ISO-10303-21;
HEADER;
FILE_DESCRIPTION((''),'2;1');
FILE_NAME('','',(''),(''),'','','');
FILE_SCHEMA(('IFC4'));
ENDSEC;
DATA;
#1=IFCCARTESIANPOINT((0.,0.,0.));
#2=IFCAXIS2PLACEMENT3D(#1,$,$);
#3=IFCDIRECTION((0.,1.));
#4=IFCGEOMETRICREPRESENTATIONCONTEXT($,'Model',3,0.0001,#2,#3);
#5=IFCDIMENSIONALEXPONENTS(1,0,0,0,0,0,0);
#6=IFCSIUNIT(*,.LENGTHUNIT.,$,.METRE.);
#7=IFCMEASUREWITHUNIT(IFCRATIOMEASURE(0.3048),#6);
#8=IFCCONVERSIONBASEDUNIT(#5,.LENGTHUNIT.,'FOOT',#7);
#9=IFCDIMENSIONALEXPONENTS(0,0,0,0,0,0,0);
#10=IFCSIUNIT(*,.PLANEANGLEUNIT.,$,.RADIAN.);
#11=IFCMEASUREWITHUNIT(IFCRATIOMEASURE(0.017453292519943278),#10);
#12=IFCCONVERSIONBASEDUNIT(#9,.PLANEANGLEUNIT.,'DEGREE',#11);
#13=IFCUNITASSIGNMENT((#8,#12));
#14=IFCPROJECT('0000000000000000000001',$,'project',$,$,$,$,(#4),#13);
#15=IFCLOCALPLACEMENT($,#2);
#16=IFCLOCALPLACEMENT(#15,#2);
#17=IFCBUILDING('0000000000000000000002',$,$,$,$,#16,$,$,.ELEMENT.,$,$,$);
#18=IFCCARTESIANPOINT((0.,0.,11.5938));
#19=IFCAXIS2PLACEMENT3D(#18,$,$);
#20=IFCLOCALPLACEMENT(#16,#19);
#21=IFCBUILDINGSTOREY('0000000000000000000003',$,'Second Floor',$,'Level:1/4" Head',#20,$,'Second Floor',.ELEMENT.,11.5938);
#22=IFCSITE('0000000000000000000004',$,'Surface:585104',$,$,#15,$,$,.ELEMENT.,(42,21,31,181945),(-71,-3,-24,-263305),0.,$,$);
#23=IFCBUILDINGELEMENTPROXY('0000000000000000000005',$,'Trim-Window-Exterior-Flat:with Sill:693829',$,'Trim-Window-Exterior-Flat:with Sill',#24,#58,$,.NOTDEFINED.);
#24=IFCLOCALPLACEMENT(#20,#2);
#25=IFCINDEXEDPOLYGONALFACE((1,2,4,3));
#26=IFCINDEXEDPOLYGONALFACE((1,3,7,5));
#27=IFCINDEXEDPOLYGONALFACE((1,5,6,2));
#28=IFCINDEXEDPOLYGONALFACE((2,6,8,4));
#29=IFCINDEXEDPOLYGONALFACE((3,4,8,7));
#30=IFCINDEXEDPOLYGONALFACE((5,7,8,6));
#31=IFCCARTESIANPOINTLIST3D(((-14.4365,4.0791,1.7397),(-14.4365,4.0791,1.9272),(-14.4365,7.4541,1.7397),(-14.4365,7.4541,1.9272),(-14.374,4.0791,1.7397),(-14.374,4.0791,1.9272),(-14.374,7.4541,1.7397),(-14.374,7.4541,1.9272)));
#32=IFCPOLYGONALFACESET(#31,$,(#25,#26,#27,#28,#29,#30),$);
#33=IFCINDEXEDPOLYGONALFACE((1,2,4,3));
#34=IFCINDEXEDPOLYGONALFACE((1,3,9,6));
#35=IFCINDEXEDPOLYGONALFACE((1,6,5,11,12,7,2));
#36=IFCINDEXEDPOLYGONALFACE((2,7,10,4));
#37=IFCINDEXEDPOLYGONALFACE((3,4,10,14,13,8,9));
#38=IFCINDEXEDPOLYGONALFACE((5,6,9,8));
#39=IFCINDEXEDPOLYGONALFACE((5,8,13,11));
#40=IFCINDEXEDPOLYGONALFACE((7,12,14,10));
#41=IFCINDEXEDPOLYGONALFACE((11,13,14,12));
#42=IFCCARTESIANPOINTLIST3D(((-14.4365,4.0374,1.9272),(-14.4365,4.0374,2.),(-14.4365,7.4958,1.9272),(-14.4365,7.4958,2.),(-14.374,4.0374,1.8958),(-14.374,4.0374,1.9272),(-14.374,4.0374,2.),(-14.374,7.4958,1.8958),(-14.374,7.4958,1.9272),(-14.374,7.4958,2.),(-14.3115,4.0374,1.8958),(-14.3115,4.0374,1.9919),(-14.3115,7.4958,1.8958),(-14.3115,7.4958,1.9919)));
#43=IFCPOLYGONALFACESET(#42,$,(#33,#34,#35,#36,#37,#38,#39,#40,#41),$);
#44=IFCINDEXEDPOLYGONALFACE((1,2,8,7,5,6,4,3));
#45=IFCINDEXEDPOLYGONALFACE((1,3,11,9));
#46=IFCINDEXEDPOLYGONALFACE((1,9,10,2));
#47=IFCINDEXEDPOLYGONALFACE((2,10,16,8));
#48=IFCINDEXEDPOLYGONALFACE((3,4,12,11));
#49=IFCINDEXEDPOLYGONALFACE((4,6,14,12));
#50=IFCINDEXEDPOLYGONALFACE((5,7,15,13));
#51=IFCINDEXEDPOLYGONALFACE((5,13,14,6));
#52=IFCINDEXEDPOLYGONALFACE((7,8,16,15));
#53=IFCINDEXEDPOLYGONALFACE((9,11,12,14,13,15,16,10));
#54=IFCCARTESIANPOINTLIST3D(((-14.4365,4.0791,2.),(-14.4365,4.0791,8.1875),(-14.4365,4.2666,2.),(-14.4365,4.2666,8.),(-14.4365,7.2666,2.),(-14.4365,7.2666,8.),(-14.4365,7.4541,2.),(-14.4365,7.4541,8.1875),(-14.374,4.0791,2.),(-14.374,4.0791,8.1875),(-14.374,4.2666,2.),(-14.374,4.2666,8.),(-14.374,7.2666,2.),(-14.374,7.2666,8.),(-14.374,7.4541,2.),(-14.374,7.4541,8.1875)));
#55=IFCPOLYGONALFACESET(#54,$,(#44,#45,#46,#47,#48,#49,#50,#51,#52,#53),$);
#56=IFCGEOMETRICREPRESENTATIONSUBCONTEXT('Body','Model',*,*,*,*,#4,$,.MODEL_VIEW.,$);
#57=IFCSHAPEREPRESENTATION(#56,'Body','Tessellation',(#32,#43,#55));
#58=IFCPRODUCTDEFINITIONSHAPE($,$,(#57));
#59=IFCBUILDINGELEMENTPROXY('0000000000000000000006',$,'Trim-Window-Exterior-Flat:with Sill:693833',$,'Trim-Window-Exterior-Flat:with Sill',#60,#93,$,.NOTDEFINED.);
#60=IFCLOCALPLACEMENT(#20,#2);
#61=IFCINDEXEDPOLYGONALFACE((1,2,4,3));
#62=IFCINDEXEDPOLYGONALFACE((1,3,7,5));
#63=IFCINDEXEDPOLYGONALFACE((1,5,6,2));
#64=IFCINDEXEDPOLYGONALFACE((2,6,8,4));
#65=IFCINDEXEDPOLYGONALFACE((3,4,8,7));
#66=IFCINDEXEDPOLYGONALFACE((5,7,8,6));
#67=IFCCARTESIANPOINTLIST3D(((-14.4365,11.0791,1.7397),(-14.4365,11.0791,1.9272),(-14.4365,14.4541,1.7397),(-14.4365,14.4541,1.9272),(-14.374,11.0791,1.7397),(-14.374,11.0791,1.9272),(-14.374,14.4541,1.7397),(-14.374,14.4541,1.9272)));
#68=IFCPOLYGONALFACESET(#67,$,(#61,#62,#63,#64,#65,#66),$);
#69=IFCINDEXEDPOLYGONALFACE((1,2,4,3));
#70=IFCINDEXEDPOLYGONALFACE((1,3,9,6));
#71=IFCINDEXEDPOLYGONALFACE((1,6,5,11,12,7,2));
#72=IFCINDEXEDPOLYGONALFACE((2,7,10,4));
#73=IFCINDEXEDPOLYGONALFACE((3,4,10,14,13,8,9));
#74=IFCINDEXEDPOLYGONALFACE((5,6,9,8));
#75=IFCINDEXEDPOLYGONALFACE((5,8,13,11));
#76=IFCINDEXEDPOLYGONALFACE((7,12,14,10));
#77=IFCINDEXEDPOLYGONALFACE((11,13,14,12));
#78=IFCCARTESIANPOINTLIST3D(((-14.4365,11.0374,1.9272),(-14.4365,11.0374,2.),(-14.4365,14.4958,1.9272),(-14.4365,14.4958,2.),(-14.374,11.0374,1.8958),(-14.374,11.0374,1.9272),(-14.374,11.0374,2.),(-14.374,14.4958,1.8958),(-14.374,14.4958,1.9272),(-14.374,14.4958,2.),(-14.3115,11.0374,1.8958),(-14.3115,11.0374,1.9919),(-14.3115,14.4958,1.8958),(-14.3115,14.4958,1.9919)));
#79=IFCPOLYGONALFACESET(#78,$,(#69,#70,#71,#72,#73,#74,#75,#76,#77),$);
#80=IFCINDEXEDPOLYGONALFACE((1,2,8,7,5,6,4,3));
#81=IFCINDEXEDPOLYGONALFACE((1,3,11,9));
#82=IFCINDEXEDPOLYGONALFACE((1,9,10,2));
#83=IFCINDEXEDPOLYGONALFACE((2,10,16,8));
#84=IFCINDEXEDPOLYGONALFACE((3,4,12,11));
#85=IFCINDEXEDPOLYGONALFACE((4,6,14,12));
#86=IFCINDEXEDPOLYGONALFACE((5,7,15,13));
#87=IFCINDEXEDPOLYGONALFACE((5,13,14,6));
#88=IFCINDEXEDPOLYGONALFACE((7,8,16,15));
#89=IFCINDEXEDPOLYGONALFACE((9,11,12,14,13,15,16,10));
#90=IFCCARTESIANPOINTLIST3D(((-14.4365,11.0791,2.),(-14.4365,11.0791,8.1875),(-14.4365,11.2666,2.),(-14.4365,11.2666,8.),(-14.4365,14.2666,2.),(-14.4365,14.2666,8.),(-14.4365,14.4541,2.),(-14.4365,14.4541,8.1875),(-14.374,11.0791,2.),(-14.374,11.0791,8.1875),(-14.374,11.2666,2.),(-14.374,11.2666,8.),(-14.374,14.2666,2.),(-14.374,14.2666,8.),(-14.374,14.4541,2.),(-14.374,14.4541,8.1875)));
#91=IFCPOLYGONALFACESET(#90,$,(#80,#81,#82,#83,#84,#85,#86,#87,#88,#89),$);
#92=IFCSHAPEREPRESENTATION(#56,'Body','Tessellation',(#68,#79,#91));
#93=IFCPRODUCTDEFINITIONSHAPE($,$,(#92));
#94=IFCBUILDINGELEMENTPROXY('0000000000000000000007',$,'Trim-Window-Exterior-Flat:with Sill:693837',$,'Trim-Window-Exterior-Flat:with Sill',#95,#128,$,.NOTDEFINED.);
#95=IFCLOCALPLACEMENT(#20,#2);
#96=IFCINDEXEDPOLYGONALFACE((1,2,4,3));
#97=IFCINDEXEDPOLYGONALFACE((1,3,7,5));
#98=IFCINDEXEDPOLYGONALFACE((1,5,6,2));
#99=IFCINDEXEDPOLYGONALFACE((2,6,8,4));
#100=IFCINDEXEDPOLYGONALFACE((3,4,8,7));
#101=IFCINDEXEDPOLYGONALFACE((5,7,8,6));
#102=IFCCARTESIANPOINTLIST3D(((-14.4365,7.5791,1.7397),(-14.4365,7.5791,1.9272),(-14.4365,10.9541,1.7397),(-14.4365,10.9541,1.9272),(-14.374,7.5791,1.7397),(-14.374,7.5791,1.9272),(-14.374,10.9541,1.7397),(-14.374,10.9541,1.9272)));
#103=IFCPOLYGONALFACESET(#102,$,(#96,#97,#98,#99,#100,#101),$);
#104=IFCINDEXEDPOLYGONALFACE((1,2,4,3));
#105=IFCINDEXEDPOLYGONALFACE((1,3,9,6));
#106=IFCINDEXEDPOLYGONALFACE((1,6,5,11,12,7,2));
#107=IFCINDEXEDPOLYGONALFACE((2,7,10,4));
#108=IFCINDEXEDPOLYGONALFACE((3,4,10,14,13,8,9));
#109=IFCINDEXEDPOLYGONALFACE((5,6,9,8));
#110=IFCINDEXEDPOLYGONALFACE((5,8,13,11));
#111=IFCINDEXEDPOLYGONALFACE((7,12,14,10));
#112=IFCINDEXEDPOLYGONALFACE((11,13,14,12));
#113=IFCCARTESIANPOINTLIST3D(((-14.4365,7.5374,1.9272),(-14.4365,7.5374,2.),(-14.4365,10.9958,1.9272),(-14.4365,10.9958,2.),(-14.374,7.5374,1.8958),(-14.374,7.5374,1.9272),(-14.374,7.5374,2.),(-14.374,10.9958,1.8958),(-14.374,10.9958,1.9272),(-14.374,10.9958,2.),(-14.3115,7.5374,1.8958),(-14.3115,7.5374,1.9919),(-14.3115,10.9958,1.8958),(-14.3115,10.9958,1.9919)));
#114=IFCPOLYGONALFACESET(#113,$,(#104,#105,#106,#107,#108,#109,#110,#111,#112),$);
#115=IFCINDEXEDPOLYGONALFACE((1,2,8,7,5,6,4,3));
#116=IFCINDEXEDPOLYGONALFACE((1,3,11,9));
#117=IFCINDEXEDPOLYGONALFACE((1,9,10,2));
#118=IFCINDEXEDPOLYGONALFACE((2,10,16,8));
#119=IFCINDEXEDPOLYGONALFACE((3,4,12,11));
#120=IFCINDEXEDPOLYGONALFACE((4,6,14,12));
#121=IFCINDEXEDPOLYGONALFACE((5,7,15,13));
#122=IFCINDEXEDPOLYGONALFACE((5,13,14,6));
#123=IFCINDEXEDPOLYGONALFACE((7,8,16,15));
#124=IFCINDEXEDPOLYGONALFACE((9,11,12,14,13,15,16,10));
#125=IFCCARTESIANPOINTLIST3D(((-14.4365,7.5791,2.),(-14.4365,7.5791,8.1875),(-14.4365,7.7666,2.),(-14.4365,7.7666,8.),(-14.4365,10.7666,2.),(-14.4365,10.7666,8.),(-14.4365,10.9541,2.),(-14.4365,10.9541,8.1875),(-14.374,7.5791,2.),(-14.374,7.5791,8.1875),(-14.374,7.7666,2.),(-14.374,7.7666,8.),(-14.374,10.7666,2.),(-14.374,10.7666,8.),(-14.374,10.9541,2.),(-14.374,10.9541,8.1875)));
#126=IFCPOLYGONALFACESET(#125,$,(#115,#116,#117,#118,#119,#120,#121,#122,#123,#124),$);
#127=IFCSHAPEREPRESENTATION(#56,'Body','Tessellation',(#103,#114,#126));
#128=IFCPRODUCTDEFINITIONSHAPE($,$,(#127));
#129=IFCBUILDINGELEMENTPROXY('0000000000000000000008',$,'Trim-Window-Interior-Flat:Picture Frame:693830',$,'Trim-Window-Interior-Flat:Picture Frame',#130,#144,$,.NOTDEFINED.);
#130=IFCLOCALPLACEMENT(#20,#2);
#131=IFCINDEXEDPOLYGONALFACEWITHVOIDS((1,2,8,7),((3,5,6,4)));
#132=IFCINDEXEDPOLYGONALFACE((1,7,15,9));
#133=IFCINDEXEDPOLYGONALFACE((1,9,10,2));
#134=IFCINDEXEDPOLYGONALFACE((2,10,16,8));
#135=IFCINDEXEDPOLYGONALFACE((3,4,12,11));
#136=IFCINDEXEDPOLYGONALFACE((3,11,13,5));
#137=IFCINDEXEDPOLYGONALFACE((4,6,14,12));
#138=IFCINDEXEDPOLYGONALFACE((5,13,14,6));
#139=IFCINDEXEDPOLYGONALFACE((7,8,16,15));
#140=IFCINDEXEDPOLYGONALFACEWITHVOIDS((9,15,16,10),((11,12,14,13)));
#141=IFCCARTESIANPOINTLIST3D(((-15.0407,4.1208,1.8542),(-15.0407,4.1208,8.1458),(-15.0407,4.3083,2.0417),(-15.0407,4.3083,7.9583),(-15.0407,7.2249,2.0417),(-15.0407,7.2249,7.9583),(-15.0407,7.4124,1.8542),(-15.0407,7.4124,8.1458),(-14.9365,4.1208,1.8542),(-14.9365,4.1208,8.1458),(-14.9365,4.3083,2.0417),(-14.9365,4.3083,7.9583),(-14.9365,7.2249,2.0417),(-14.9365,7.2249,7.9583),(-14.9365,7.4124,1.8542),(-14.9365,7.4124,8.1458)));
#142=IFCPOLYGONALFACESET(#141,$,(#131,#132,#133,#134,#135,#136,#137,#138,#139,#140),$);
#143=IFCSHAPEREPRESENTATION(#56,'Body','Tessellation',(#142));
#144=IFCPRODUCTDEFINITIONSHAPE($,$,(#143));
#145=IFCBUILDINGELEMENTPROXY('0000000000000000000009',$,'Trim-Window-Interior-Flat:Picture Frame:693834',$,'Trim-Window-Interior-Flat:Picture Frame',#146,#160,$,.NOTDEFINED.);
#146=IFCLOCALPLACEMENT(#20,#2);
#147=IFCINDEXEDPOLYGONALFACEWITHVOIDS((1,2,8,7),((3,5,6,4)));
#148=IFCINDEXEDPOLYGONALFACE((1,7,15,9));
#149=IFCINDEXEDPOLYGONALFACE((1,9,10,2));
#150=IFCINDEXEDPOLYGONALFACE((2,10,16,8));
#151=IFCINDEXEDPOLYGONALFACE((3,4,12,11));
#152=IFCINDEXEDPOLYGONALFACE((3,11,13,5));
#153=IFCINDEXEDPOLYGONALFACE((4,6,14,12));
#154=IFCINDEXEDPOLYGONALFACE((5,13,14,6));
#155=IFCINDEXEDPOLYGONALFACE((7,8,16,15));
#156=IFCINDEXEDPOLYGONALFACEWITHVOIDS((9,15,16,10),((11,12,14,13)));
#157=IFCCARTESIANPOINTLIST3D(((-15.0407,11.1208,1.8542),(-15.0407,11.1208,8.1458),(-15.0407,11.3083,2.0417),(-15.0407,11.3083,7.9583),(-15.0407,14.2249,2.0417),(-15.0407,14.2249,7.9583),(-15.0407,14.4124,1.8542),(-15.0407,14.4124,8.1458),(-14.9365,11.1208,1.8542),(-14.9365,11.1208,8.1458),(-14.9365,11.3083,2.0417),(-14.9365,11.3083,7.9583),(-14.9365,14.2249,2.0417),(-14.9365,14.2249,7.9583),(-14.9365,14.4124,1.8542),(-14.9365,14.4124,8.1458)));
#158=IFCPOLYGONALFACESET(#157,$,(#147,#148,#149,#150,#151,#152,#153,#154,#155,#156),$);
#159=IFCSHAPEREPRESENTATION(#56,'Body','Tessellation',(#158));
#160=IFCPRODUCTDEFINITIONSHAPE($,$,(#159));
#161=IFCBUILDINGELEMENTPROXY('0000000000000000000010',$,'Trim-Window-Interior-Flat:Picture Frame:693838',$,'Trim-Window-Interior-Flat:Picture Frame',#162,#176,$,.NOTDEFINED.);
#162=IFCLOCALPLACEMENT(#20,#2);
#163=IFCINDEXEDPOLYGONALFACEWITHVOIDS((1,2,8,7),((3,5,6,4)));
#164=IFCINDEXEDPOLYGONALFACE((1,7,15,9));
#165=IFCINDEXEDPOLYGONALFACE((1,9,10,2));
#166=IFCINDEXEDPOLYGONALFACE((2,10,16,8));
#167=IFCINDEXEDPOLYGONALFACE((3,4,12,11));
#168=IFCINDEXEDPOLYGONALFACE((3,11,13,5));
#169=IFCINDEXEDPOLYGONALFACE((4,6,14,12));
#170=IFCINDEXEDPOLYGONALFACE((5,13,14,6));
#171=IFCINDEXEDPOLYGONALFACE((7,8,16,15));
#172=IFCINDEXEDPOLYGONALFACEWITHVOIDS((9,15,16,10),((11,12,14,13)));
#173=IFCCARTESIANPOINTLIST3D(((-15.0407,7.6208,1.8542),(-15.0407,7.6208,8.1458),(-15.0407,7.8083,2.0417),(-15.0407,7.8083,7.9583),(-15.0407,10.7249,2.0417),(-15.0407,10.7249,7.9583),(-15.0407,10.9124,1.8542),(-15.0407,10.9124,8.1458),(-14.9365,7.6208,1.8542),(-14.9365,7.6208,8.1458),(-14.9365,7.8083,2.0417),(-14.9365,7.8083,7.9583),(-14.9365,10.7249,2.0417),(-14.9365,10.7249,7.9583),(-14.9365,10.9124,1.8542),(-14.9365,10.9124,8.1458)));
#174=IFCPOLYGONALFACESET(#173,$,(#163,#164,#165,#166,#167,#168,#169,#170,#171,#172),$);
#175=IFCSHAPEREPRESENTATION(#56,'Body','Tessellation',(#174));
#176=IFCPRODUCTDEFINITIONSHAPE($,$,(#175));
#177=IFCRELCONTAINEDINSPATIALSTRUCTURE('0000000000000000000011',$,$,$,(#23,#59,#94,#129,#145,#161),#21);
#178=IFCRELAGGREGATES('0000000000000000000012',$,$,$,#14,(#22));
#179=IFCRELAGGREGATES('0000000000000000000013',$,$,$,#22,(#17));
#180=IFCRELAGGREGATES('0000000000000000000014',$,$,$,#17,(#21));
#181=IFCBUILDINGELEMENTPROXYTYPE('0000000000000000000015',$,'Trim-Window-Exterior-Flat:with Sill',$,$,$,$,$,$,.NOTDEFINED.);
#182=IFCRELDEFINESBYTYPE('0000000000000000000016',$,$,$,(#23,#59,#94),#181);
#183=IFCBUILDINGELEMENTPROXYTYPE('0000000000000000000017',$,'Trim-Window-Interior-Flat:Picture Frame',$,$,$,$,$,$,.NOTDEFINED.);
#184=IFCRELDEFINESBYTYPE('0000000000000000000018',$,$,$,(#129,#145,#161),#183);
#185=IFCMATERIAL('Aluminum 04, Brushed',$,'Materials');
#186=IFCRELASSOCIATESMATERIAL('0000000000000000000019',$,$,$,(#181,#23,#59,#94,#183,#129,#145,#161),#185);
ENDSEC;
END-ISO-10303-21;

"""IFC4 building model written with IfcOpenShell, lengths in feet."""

from ifc_helpers import new_model, entity, si_unit, converted_unit, direction, frame, origin, place, context, subcontext, project, spatial, indexed_curve, outline, extrude, source, transform, mapped, material, type_object, type_shapes, element, save


model = new_model("IFC4")

# Units and contexts
model_context = context("Model", 3, precision=0.0001, world=origin(), true_north=direction((0.0, 1.0)))
body_context = subcontext(model_context, "Body", "Model", "MODEL_VIEW")
ifc_project = project(units=[converted_unit("LENGTHUNIT", "FOOT", entity("IfcRatioMeasure", 0.3048), si_unit("LENGTHUNIT", "METRE"), dimensions=[1, 0, 0, 0, 0, 0, 0]), converted_unit("PLANEANGLEUNIT", "DEGREE", entity("IfcRatioMeasure", 0.017453292519943278), si_unit("PLANEANGLEUNIT", "RADIAN"), dimensions=[0, 0, 0, 0, 0, 0, 0])], contexts=[model_context])

# Site, building, storey
site_placement = place(None, origin())
site = spatial("IfcSite", under=ifc_project, at=site_placement, Name="Surface:585104", CompositionType="ELEMENT", RefLatitude=(42, 21, 31, 181945), RefLongitude=(-71, -3, -24, -263305), RefElevation=0.0)
building_placement = place(site_placement, origin())
building = spatial("IfcBuilding", under=site, at=building_placement, CompositionType="ELEMENT")
storey_placement = place(building_placement, frame((0.0, 0.0, 11.5938)))
storey = spatial("IfcBuildingStorey", under=building, at=storey_placement, Name="Second Floor", ObjectType="Level:1/4\" Head", LongName="Second Floor", CompositionType="ELEMENT", Elevation=11.5938)

# Shared definitions
ifc_material_1 = material(Name="Aluminum 04, Brushed", Category="Materials")

# Building element proxies
building_element_proxy_type_1 = type_object("IfcBuildingElementProxyType", Name="Trim-Window-Exterior-Flat:with Sill", PredefinedType="NOTDEFINED", material=ifc_material_1)
shared_shape_1 = source(origin(), body_context, "Body", "SweptSolid", [
    extrude(outline(indexed_curve([(-0.0938, -1.6875), (0.0938, -1.6875), (0.0938, 1.6875), (-0.0938, 1.6875), (-0.0938, -1.6875)], self_intersect=False)), frame((0.0, 6.1665, 0.0), z_axis=(0.0, 0.0, 1.0), x_axis=(0.0, 1.0, 0.0)), (0.0, 0.0, 1.0), 0.0625),
    extrude(outline(indexed_curve([(-0.0525, -0.0625), (0.0436, -0.0625), (0.0517, 0.0), (0.0517, 0.0625), (-0.0211, 0.0625), (-0.0211, 0.0), (-0.0525, 0.0), (-0.0525, -0.0625)], self_intersect=False)), frame((-1.7292, 6.0517, 0.0625), z_axis=(1.0, 0.0, 0.0), x_axis=(0.0, -1.0, 0.0)), (0.0, 0.0, 1.0), 3.4583),
    extrude(outline(indexed_curve([(-1.6875, -3.1406), (1.6875, -3.1406), (1.6875, 3.0469), (1.5, 3.0469), (1.5, -2.9531), (-1.5, -2.9531), (-1.5, 3.0469), (-1.6875, 3.0469), (-1.6875, -3.1406)], self_intersect=False)), frame((0.0, 2.9531, 0.0)), (0.0, 0.0, 1.0), 0.0625),
])
type_shapes(building_element_proxy_type_1, [shared_shape_1])
for number, where, z_axis, x_axis, name in (
    (1, (-14.4365, 5.7666, 8.0), (1.0, 0.0, 0.0), (0.0, -1.0, 0.0), "Trim-Window-Exterior-Flat:with Sill:693829"),
    (2, (-14.4365, 12.7666, 8.0), (1.0, 0.0, 0.0), (0.0, -1.0, 0.0), "Trim-Window-Exterior-Flat:with Sill:693833"),
    (3, (-14.4365, 9.2666, 8.0), (1.0, 0.0, 0.0), (0.0, -1.0, 0.0), "Trim-Window-Exterior-Flat:with Sill:693837"),
):
    element("IfcBuildingElementProxy", number, at=place(storey_placement, frame(where, z_axis=z_axis, x_axis=x_axis)), inside=storey, type_object=building_element_proxy_type_1, material=ifc_material_1, Name=name, ObjectType="Trim-Window-Exterior-Flat:with Sill", PredefinedType="NOTDEFINED", context=body_context, shape_type="MappedRepresentation", body=[
        mapped(shared_shape_1, transform((0.0, 0.0, 0.0), scale=1.0)),
    ])
building_element_proxy_type_2 = type_object("IfcBuildingElementProxyType", Name="Trim-Window-Interior-Flat:Picture Frame", PredefinedType="NOTDEFINED", material=ifc_material_1)
shared_shape_2 = source(origin(), body_context, "Body", "SweptSolid", [
    extrude(outline(indexed_curve([(-3.1458, -1.6458), (3.1458, -1.6458), (3.1458, 1.6458), (-3.1458, 1.6458), (-3.1458, -1.6458)], self_intersect=False), holes=[indexed_curve([(-2.9583, -1.4583), (-2.9583, 1.4583), (2.9583, 1.4583), (2.9583, -1.4583), (-2.9583, -1.4583)], self_intersect=False)]), frame((0.0, 3.0, 0.0), z_axis=(0.0, 0.0, 1.0), x_axis=(0.0, 1.0, 0.0)), (0.0, 0.0, 1.0), 0.1042),
])
type_shapes(building_element_proxy_type_2, [shared_shape_2])
for number, where, z_axis, x_axis, name in (
    (4, (-14.9365, 5.7666, 8.0), (-1.0, 0.0, 0.0), (0.0, 1.0, 0.0), "Trim-Window-Interior-Flat:Picture Frame:693830"),
    (5, (-14.9365, 12.7666, 8.0), (-1.0, 0.0, 0.0), (0.0, 1.0, 0.0), "Trim-Window-Interior-Flat:Picture Frame:693834"),
    (6, (-14.9365, 9.2666, 8.0), (-1.0, 0.0, 0.0), (0.0, 1.0, 0.0), "Trim-Window-Interior-Flat:Picture Frame:693838"),
):
    element("IfcBuildingElementProxy", number, at=place(storey_placement, frame(where, z_axis=z_axis, x_axis=x_axis)), inside=storey, type_object=building_element_proxy_type_2, material=ifc_material_1, Name=name, ObjectType="Trim-Window-Interior-Flat:Picture Frame", PredefinedType="NOTDEFINED", context=body_context, shape_type="MappedRepresentation", body=[
        mapped(shared_shape_2, transform((0.0, 0.0, 0.0), scale=1.0)),
    ])

save(model, "model.ifc")
